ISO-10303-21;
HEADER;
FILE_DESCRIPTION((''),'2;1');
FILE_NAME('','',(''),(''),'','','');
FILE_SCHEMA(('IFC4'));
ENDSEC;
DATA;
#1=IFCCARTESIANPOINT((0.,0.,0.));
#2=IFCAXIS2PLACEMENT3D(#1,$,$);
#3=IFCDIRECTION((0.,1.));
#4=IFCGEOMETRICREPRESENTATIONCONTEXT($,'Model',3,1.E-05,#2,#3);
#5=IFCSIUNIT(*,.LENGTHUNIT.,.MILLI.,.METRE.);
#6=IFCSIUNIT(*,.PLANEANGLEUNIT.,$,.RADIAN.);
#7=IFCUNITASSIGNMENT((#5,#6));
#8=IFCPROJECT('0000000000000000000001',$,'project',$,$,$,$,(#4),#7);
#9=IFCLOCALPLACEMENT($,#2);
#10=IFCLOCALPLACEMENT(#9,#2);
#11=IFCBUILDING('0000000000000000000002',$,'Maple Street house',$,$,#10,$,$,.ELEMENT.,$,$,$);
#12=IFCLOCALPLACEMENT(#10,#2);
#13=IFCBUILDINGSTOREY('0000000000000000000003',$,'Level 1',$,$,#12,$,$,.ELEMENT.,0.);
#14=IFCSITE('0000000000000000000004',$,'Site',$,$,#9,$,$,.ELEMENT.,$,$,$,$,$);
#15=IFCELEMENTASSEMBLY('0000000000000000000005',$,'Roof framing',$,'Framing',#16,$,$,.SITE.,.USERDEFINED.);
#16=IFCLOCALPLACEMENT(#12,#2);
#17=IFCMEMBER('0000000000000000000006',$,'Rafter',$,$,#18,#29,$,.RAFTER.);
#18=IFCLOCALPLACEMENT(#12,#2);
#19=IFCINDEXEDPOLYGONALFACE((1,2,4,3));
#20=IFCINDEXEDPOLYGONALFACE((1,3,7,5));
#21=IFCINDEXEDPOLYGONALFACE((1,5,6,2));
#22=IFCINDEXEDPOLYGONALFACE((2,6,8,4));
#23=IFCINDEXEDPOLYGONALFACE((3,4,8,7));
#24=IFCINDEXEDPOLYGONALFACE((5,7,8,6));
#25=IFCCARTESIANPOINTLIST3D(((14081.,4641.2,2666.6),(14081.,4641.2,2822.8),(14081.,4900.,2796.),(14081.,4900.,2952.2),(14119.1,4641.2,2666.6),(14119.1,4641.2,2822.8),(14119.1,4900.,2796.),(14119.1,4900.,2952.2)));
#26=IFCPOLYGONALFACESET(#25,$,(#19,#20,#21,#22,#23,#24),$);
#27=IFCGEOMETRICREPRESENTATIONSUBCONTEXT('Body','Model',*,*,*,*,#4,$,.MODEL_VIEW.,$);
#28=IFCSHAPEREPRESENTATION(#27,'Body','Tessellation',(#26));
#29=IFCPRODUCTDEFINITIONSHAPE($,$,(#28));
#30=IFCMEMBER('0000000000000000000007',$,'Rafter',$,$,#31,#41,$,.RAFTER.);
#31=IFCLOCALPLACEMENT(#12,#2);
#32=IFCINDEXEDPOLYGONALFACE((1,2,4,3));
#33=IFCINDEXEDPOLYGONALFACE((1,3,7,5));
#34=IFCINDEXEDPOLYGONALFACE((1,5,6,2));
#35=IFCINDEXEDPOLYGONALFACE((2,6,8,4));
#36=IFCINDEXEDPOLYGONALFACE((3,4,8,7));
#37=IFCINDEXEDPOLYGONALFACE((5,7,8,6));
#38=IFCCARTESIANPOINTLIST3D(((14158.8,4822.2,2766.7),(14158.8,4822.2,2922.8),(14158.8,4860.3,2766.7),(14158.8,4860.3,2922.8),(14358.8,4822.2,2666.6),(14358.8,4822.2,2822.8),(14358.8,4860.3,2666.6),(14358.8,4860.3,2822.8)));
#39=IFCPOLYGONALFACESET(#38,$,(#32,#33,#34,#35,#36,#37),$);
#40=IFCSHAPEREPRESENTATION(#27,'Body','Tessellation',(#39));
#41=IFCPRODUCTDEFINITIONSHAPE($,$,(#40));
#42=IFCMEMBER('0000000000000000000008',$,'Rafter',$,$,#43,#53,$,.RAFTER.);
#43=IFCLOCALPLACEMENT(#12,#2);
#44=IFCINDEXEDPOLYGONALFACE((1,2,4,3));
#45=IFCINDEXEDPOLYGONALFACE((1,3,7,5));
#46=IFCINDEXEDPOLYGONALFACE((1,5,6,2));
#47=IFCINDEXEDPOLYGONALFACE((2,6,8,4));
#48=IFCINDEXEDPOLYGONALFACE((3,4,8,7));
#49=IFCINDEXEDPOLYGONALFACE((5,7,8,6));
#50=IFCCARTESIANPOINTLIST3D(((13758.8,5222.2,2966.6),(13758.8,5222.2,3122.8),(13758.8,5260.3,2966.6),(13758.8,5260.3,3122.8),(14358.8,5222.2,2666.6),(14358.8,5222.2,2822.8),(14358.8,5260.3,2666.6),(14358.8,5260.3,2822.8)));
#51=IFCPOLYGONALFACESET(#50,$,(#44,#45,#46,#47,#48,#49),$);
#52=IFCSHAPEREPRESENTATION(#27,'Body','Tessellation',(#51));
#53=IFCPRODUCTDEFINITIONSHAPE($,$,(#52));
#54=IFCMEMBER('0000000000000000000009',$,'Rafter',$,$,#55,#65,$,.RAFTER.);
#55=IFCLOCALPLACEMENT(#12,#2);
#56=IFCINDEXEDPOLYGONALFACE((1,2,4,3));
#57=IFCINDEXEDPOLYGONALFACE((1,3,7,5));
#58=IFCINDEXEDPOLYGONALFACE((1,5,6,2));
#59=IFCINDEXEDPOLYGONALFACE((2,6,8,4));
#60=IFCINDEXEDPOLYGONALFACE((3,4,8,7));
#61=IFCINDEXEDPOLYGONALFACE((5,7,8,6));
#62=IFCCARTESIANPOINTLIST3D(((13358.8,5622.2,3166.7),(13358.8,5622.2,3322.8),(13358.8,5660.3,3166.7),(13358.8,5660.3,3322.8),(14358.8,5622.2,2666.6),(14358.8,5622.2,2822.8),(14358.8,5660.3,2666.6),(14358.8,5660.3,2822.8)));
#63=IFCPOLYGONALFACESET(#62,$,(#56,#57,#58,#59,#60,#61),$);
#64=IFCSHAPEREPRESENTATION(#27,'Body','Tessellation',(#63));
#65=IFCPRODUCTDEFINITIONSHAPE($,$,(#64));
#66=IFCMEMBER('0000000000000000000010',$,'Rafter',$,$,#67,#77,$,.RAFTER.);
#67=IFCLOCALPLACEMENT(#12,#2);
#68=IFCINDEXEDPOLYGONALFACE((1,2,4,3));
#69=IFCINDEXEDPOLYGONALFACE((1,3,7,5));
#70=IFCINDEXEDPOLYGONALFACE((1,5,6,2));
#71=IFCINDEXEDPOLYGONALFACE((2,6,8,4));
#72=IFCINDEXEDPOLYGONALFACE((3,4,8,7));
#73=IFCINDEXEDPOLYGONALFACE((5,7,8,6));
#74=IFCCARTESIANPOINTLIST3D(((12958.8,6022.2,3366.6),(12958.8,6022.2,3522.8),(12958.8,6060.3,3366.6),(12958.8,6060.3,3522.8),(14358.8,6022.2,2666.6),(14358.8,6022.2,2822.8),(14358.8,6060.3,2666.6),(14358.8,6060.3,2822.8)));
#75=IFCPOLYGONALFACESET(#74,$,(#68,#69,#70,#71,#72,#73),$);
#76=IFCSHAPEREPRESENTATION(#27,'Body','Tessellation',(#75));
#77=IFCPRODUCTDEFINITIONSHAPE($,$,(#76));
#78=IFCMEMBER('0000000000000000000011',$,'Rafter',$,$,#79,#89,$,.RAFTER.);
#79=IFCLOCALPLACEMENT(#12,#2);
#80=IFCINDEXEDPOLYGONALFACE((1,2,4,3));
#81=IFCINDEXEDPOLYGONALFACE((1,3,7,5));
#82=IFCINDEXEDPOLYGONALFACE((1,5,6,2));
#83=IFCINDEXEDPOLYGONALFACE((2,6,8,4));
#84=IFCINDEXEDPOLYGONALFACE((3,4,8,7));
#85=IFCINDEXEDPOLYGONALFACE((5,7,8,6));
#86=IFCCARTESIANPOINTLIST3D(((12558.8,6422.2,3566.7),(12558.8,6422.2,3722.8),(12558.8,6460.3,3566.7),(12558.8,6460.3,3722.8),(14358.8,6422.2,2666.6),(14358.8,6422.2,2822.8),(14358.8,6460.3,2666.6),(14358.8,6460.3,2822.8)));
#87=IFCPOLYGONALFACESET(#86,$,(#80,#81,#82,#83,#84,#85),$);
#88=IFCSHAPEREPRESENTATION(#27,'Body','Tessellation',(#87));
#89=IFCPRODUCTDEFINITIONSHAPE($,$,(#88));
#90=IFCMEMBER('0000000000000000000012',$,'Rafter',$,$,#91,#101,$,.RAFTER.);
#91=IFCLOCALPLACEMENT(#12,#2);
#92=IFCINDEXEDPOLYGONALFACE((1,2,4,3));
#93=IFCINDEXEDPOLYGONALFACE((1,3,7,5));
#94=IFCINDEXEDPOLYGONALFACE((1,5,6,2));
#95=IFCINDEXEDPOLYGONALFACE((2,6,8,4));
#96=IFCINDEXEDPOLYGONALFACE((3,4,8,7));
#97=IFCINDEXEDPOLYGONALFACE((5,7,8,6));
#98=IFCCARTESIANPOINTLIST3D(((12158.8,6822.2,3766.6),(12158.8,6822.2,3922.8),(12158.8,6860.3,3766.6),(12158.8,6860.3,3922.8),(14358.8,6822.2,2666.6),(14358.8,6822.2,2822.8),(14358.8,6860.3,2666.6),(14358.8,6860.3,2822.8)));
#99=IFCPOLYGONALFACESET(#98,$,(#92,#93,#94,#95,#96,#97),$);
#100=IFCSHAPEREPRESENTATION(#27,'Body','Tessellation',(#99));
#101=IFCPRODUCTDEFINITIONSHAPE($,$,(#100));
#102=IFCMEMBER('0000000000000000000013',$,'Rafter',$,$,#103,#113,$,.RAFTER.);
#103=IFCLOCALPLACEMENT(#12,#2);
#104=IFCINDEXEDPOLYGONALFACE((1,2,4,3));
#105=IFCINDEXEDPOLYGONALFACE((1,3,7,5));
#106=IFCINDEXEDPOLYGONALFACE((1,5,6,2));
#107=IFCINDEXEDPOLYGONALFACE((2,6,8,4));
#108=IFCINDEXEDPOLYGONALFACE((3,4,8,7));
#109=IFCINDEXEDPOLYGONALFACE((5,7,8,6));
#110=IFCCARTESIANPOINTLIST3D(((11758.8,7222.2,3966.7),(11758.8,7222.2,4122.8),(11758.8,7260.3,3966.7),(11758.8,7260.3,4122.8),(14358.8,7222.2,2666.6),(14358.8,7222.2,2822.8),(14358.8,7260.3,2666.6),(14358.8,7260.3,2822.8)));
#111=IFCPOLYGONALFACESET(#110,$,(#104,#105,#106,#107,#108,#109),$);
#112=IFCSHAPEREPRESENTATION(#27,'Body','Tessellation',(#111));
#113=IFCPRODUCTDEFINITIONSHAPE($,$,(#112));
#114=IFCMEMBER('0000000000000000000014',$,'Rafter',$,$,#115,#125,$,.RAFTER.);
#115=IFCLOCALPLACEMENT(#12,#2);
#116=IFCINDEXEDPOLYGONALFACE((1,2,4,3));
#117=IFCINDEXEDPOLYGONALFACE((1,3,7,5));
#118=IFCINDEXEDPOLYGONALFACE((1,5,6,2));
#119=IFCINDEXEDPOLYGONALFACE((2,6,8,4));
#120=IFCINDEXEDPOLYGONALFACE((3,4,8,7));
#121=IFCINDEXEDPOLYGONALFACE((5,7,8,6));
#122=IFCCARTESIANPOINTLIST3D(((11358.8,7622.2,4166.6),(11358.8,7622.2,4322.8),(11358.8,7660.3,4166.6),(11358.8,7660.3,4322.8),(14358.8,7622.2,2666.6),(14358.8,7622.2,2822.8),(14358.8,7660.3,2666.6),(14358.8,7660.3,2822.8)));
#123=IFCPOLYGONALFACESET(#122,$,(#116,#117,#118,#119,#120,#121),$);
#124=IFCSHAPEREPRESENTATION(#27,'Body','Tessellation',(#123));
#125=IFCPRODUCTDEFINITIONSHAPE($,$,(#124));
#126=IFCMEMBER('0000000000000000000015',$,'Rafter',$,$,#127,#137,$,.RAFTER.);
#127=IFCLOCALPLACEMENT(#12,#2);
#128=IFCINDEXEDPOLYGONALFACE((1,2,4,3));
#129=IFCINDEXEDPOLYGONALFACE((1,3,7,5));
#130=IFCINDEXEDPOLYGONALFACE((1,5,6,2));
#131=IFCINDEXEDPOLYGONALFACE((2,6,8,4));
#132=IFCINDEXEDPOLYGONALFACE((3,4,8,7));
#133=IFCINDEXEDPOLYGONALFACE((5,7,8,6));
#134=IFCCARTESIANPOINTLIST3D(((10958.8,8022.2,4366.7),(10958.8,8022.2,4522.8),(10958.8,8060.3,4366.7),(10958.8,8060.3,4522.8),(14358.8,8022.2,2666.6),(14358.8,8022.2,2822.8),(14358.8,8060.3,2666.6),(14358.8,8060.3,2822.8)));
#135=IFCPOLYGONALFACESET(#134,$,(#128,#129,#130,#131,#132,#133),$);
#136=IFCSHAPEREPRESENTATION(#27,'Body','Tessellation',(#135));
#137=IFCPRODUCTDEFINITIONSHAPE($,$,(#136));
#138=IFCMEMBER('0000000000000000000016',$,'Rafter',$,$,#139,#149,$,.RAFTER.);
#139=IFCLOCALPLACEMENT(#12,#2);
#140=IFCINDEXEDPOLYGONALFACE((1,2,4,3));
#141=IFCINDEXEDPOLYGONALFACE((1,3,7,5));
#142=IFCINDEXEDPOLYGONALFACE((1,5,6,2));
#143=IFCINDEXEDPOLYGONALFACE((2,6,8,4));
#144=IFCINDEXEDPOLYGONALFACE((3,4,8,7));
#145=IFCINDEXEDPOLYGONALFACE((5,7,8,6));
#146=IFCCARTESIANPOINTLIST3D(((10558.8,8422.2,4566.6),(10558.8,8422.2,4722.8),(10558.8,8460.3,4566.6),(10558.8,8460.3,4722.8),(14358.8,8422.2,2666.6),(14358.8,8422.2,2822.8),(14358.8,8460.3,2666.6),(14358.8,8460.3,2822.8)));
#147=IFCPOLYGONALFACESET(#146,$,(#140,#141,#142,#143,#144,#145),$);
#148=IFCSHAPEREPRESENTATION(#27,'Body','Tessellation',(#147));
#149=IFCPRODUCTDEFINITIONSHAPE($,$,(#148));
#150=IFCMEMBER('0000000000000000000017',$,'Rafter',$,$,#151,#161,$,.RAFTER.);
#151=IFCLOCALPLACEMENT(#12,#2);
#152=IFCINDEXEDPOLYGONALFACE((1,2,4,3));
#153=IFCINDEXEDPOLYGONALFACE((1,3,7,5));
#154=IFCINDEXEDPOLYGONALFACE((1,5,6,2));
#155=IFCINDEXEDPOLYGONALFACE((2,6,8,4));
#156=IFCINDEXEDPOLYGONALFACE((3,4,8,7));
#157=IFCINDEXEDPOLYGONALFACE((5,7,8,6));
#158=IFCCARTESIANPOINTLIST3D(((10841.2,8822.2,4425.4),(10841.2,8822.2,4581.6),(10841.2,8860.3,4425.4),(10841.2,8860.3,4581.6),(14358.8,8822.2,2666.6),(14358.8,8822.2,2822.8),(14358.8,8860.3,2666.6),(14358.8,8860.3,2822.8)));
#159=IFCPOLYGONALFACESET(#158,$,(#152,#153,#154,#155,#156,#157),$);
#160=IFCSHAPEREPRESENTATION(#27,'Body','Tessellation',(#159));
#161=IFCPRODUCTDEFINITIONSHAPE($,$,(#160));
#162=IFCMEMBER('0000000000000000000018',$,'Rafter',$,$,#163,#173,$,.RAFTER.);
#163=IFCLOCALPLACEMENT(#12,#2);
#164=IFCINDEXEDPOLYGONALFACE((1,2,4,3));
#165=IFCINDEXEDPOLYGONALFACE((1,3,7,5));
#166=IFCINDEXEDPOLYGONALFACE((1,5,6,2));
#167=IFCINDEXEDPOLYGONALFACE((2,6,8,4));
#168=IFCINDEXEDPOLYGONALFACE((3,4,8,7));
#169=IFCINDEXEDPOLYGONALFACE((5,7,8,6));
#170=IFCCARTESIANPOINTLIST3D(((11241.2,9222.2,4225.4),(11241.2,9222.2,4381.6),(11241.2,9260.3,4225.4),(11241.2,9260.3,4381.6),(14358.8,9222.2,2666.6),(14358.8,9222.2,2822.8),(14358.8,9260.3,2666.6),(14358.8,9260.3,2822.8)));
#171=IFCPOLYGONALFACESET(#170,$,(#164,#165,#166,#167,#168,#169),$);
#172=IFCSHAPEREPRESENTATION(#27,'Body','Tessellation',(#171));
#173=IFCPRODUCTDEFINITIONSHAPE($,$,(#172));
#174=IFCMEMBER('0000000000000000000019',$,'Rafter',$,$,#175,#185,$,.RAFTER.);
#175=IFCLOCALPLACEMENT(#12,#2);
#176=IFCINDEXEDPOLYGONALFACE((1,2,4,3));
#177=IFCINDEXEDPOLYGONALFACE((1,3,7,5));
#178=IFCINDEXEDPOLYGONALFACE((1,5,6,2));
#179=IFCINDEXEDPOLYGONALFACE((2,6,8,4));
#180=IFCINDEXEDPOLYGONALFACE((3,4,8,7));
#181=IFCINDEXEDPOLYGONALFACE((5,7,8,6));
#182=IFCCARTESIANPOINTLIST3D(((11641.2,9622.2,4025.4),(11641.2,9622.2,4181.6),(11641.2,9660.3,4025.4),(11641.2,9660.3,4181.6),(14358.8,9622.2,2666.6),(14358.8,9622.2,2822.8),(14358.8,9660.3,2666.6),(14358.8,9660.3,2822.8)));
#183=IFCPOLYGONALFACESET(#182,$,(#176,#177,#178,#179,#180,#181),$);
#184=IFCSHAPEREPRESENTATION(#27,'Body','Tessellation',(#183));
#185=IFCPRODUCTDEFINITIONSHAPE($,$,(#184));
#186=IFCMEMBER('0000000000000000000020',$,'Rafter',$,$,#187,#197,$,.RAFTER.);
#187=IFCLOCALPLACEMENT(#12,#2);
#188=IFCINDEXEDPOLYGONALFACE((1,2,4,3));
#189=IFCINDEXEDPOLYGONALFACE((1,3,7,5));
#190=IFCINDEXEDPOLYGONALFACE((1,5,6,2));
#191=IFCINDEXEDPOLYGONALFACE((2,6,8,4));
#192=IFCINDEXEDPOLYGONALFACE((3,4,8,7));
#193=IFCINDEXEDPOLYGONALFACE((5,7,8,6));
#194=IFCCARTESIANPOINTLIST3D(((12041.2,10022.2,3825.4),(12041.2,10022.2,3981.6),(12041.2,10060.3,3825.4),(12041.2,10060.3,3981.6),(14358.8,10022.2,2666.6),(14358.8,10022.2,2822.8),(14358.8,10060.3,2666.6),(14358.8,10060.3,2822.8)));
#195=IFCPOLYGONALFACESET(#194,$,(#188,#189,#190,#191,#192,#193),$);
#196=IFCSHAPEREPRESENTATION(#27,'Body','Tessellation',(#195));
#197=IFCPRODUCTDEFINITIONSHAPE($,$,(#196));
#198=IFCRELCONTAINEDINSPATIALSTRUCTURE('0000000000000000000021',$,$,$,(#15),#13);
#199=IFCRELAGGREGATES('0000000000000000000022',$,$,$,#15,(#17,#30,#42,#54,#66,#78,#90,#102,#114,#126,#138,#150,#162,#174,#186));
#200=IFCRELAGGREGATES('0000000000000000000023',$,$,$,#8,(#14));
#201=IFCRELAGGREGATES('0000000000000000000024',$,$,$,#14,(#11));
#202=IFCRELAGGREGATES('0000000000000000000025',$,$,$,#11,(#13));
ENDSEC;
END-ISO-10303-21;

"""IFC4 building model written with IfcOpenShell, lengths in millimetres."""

from ifc_helpers import new_model, si_unit, direction, frame, origin, origin_with_axes, place, context, subcontext, project, spatial, polyline, outline, extrude, element, aggregate, save


model = new_model("IFC4")

# Units and contexts
model_context = context("Model", 3, precision=1e-05, world=origin(), true_north=direction((0.0, 1.0)))
body_context = subcontext(model_context, "Body", "Model", "MODEL_VIEW")
ifc_project = project(units=[si_unit("LENGTHUNIT", "METRE", prefix="MILLI"), si_unit("PLANEANGLEUNIT", "RADIAN")], contexts=[model_context])

# Site, building, storey
site_placement = place(None, origin())
site = spatial("IfcSite", under=ifc_project, at=site_placement, Name="Site", CompositionType="ELEMENT")
building_placement = place(site_placement, origin())
building = spatial("IfcBuilding", under=site, at=building_placement, Name="Maple Street house", CompositionType="ELEMENT")
storey_placement = place(building_placement, origin())
storey = spatial("IfcBuildingStorey", under=building, at=storey_placement, Name="Level 1", CompositionType="ELEMENT", Elevation=0.0)

# Element assembly, members
assembly_placement = place(storey_placement, origin_with_axes())
assembly = element("IfcElementAssembly", 1, at=assembly_placement, inside=storey, Name="Roof framing", ObjectType="Framing", AssemblyPlace="SITE", PredefinedType="USERDEFINED")
member_1_placement = place(storey_placement, origin_with_axes())
member_1 = element("IfcMember", 2, at=member_1_placement, Name="Rafter", PredefinedType="RAFTER", context=body_context, shape_type="SweptSolid", body=[
    extrude(outline(polyline([(0.0, 0.0), (38.1, 0.0), (38.1, 156.2), (0.0, 156.2), (0.0, 0.0)])), frame((14119.1, 4641.2, 2666.7), z_axis=(0.0, 1.0, 0.0), x_axis=(-1.0, 0.0, 0.0)), (0.0, 0.447214, 0.894427), 289.3),
])
member_2_placement = place(storey_placement, origin_with_axes())
member_2 = element("IfcMember", 3, at=member_2_placement, Name="Rafter", PredefinedType="RAFTER", context=body_context, shape_type="SweptSolid", body=[
    extrude(outline(polyline([(0.0, 0.0), (38.1, 0.0), (38.1, 156.2), (0.0, 156.2), (0.0, 0.0)])), frame((14358.8, 4860.3, 2666.7), z_axis=(-1.0, 0.0, 0.0), x_axis=(0.0, -1.0, 0.0)), (0.0, 0.447214, 0.894427), 223.6),
])
member_3_placement = place(storey_placement, origin_with_axes())
member_3 = element("IfcMember", 4, at=member_3_placement, Name="Rafter", PredefinedType="RAFTER", context=body_context, shape_type="SweptSolid", body=[
    extrude(outline(polyline([(0.0, 0.0), (38.1, 0.0), (38.1, 156.2), (0.0, 156.2), (0.0, 0.0)])), frame((14358.8, 5260.3, 2666.7), z_axis=(-1.0, 0.0, 0.0), x_axis=(0.0, -1.0, 0.0)), (0.0, 0.447214, 0.894427), 670.8),
])
member_4_placement = place(storey_placement, origin_with_axes())
member_4 = element("IfcMember", 5, at=member_4_placement, Name="Rafter", PredefinedType="RAFTER", context=body_context, shape_type="SweptSolid", body=[
    extrude(outline(polyline([(0.0, 0.0), (38.1, 0.0), (38.1, 156.2), (0.0, 156.2), (0.0, 0.0)])), frame((14358.8, 5660.3, 2666.7), z_axis=(-1.0, 0.0, 0.0), x_axis=(0.0, -1.0, 0.0)), (0.0, 0.447214, 0.894427), 1118.0),
])
member_5_placement = place(storey_placement, origin_with_axes())
member_5 = element("IfcMember", 6, at=member_5_placement, Name="Rafter", PredefinedType="RAFTER", context=body_context, shape_type="SweptSolid", body=[
    extrude(outline(polyline([(0.0, 0.0), (38.1, 0.0), (38.1, 156.2), (0.0, 156.2), (0.0, 0.0)])), frame((14358.8, 6060.3, 2666.7), z_axis=(-1.0, 0.0, 0.0), x_axis=(0.0, -1.0, 0.0)), (0.0, 0.447214, 0.894427), 1565.2),
])
member_6_placement = place(storey_placement, origin_with_axes())
member_6 = element("IfcMember", 7, at=member_6_placement, Name="Rafter", PredefinedType="RAFTER", context=body_context, shape_type="SweptSolid", body=[
    extrude(outline(polyline([(0.0, 0.0), (38.1, 0.0), (38.1, 156.2), (0.0, 156.2), (0.0, 0.0)])), frame((14358.8, 6460.3, 2666.7), z_axis=(-1.0, 0.0, 0.0), x_axis=(0.0, -1.0, 0.0)), (0.0, 0.447214, 0.894427), 2012.5),
])
member_7_placement = place(storey_placement, origin_with_axes())
member_7 = element("IfcMember", 8, at=member_7_placement, Name="Rafter", PredefinedType="RAFTER", context=body_context, shape_type="SweptSolid", body=[
    extrude(outline(polyline([(0.0, 0.0), (38.1, 0.0), (38.1, 156.2), (0.0, 156.2), (0.0, 0.0)])), frame((14358.8, 6860.3, 2666.7), z_axis=(-1.0, 0.0, 0.0), x_axis=(0.0, -1.0, 0.0)), (0.0, 0.447214, 0.894427), 2459.7),
])
member_8_placement = place(storey_placement, origin_with_axes())
member_8 = element("IfcMember", 9, at=member_8_placement, Name="Rafter", PredefinedType="RAFTER", context=body_context, shape_type="SweptSolid", body=[
    extrude(outline(polyline([(0.0, 0.0), (38.1, 0.0), (38.1, 156.2), (0.0, 156.2), (0.0, 0.0)])), frame((14358.8, 7260.3, 2666.7), z_axis=(-1.0, 0.0, 0.0), x_axis=(0.0, -1.0, 0.0)), (0.0, 0.447214, 0.894427), 2906.9),
])
member_9_placement = place(storey_placement, origin_with_axes())
member_9 = element("IfcMember", 10, at=member_9_placement, Name="Rafter", PredefinedType="RAFTER", context=body_context, shape_type="SweptSolid", body=[
    extrude(outline(polyline([(0.0, 0.0), (38.1, 0.0), (38.1, 156.2), (0.0, 156.2), (0.0, 0.0)])), frame((14358.8, 7660.3, 2666.7), z_axis=(-1.0, 0.0, 0.0), x_axis=(0.0, -1.0, 0.0)), (0.0, 0.447214, 0.894427), 3354.1),
])
member_10_placement = place(storey_placement, origin_with_axes())
member_10 = element("IfcMember", 11, at=member_10_placement, Name="Rafter", PredefinedType="RAFTER", context=body_context, shape_type="SweptSolid", body=[
    extrude(outline(polyline([(0.0, 0.0), (38.1, 0.0), (38.1, 156.2), (0.0, 156.2), (0.0, 0.0)])), frame((14358.8, 8060.3, 2666.7), z_axis=(-1.0, 0.0, 0.0), x_axis=(0.0, -1.0, 0.0)), (0.0, 0.447214, 0.894427), 3801.3),
])
member_11_placement = place(storey_placement, origin_with_axes())
member_11 = element("IfcMember", 12, at=member_11_placement, Name="Rafter", PredefinedType="RAFTER", context=body_context, shape_type="SweptSolid", body=[
    extrude(outline(polyline([(0.0, 0.0), (38.1, 0.0), (38.1, 156.2), (0.0, 156.2), (0.0, 0.0)])), frame((14358.8, 8460.3, 2666.7), z_axis=(-1.0, 0.0, 0.0), x_axis=(0.0, -1.0, 0.0)), (0.0, 0.447214, 0.894427), 4248.5),
])
member_12_placement = place(storey_placement, origin_with_axes())
member_12 = element("IfcMember", 13, at=member_12_placement, Name="Rafter", PredefinedType="RAFTER", context=body_context, shape_type="SweptSolid", body=[
    extrude(outline(polyline([(0.0, 0.0), (38.1, 0.0), (38.1, 156.2), (0.0, 156.2), (0.0, 0.0)])), frame((14358.8, 8860.3, 2666.7), z_axis=(-1.0, 0.0, 0.0), x_axis=(0.0, -1.0, 0.0)), (0.0, 0.447214, 0.894427), 3932.7),
])
member_13_placement = place(storey_placement, origin_with_axes())
member_13 = element("IfcMember", 14, at=member_13_placement, Name="Rafter", PredefinedType="RAFTER", context=body_context, shape_type="SweptSolid", body=[
    extrude(outline(polyline([(0.0, 0.0), (38.1, 0.0), (38.1, 156.2), (0.0, 156.2), (0.0, 0.0)])), frame((14358.8, 9260.3, 2666.7), z_axis=(-1.0, 0.0, 0.0), x_axis=(0.0, -1.0, 0.0)), (0.0, 0.447214, 0.894427), 3485.5),
])
member_14_placement = place(storey_placement, origin_with_axes())
member_14 = element("IfcMember", 15, at=member_14_placement, Name="Rafter", PredefinedType="RAFTER", context=body_context, shape_type="SweptSolid", body=[
    extrude(outline(polyline([(0.0, 0.0), (38.1, 0.0), (38.1, 156.2), (0.0, 156.2), (0.0, 0.0)])), frame((14358.8, 9660.3, 2666.7), z_axis=(-1.0, 0.0, 0.0), x_axis=(0.0, -1.0, 0.0)), (0.0, 0.447214, 0.894427), 3038.3),
])
member_15_placement = place(storey_placement, origin_with_axes())
member_15 = element("IfcMember", 16, at=member_15_placement, Name="Rafter", PredefinedType="RAFTER", context=body_context, shape_type="SweptSolid", body=[
    extrude(outline(polyline([(0.0, 0.0), (38.1, 0.0), (38.1, 156.2), (0.0, 156.2), (0.0, 0.0)])), frame((14358.8, 10060.3, 2666.7), z_axis=(-1.0, 0.0, 0.0), x_axis=(0.0, -1.0, 0.0)), (0.0, 0.447214, 0.894427), 2591.1),
])
aggregate(assembly, [member_1, member_2, member_3, member_4, member_5, member_6, member_7, member_8, member_9, member_10, member_11, member_12, member_13, member_14, member_15])

save(model, "model.ifc")
